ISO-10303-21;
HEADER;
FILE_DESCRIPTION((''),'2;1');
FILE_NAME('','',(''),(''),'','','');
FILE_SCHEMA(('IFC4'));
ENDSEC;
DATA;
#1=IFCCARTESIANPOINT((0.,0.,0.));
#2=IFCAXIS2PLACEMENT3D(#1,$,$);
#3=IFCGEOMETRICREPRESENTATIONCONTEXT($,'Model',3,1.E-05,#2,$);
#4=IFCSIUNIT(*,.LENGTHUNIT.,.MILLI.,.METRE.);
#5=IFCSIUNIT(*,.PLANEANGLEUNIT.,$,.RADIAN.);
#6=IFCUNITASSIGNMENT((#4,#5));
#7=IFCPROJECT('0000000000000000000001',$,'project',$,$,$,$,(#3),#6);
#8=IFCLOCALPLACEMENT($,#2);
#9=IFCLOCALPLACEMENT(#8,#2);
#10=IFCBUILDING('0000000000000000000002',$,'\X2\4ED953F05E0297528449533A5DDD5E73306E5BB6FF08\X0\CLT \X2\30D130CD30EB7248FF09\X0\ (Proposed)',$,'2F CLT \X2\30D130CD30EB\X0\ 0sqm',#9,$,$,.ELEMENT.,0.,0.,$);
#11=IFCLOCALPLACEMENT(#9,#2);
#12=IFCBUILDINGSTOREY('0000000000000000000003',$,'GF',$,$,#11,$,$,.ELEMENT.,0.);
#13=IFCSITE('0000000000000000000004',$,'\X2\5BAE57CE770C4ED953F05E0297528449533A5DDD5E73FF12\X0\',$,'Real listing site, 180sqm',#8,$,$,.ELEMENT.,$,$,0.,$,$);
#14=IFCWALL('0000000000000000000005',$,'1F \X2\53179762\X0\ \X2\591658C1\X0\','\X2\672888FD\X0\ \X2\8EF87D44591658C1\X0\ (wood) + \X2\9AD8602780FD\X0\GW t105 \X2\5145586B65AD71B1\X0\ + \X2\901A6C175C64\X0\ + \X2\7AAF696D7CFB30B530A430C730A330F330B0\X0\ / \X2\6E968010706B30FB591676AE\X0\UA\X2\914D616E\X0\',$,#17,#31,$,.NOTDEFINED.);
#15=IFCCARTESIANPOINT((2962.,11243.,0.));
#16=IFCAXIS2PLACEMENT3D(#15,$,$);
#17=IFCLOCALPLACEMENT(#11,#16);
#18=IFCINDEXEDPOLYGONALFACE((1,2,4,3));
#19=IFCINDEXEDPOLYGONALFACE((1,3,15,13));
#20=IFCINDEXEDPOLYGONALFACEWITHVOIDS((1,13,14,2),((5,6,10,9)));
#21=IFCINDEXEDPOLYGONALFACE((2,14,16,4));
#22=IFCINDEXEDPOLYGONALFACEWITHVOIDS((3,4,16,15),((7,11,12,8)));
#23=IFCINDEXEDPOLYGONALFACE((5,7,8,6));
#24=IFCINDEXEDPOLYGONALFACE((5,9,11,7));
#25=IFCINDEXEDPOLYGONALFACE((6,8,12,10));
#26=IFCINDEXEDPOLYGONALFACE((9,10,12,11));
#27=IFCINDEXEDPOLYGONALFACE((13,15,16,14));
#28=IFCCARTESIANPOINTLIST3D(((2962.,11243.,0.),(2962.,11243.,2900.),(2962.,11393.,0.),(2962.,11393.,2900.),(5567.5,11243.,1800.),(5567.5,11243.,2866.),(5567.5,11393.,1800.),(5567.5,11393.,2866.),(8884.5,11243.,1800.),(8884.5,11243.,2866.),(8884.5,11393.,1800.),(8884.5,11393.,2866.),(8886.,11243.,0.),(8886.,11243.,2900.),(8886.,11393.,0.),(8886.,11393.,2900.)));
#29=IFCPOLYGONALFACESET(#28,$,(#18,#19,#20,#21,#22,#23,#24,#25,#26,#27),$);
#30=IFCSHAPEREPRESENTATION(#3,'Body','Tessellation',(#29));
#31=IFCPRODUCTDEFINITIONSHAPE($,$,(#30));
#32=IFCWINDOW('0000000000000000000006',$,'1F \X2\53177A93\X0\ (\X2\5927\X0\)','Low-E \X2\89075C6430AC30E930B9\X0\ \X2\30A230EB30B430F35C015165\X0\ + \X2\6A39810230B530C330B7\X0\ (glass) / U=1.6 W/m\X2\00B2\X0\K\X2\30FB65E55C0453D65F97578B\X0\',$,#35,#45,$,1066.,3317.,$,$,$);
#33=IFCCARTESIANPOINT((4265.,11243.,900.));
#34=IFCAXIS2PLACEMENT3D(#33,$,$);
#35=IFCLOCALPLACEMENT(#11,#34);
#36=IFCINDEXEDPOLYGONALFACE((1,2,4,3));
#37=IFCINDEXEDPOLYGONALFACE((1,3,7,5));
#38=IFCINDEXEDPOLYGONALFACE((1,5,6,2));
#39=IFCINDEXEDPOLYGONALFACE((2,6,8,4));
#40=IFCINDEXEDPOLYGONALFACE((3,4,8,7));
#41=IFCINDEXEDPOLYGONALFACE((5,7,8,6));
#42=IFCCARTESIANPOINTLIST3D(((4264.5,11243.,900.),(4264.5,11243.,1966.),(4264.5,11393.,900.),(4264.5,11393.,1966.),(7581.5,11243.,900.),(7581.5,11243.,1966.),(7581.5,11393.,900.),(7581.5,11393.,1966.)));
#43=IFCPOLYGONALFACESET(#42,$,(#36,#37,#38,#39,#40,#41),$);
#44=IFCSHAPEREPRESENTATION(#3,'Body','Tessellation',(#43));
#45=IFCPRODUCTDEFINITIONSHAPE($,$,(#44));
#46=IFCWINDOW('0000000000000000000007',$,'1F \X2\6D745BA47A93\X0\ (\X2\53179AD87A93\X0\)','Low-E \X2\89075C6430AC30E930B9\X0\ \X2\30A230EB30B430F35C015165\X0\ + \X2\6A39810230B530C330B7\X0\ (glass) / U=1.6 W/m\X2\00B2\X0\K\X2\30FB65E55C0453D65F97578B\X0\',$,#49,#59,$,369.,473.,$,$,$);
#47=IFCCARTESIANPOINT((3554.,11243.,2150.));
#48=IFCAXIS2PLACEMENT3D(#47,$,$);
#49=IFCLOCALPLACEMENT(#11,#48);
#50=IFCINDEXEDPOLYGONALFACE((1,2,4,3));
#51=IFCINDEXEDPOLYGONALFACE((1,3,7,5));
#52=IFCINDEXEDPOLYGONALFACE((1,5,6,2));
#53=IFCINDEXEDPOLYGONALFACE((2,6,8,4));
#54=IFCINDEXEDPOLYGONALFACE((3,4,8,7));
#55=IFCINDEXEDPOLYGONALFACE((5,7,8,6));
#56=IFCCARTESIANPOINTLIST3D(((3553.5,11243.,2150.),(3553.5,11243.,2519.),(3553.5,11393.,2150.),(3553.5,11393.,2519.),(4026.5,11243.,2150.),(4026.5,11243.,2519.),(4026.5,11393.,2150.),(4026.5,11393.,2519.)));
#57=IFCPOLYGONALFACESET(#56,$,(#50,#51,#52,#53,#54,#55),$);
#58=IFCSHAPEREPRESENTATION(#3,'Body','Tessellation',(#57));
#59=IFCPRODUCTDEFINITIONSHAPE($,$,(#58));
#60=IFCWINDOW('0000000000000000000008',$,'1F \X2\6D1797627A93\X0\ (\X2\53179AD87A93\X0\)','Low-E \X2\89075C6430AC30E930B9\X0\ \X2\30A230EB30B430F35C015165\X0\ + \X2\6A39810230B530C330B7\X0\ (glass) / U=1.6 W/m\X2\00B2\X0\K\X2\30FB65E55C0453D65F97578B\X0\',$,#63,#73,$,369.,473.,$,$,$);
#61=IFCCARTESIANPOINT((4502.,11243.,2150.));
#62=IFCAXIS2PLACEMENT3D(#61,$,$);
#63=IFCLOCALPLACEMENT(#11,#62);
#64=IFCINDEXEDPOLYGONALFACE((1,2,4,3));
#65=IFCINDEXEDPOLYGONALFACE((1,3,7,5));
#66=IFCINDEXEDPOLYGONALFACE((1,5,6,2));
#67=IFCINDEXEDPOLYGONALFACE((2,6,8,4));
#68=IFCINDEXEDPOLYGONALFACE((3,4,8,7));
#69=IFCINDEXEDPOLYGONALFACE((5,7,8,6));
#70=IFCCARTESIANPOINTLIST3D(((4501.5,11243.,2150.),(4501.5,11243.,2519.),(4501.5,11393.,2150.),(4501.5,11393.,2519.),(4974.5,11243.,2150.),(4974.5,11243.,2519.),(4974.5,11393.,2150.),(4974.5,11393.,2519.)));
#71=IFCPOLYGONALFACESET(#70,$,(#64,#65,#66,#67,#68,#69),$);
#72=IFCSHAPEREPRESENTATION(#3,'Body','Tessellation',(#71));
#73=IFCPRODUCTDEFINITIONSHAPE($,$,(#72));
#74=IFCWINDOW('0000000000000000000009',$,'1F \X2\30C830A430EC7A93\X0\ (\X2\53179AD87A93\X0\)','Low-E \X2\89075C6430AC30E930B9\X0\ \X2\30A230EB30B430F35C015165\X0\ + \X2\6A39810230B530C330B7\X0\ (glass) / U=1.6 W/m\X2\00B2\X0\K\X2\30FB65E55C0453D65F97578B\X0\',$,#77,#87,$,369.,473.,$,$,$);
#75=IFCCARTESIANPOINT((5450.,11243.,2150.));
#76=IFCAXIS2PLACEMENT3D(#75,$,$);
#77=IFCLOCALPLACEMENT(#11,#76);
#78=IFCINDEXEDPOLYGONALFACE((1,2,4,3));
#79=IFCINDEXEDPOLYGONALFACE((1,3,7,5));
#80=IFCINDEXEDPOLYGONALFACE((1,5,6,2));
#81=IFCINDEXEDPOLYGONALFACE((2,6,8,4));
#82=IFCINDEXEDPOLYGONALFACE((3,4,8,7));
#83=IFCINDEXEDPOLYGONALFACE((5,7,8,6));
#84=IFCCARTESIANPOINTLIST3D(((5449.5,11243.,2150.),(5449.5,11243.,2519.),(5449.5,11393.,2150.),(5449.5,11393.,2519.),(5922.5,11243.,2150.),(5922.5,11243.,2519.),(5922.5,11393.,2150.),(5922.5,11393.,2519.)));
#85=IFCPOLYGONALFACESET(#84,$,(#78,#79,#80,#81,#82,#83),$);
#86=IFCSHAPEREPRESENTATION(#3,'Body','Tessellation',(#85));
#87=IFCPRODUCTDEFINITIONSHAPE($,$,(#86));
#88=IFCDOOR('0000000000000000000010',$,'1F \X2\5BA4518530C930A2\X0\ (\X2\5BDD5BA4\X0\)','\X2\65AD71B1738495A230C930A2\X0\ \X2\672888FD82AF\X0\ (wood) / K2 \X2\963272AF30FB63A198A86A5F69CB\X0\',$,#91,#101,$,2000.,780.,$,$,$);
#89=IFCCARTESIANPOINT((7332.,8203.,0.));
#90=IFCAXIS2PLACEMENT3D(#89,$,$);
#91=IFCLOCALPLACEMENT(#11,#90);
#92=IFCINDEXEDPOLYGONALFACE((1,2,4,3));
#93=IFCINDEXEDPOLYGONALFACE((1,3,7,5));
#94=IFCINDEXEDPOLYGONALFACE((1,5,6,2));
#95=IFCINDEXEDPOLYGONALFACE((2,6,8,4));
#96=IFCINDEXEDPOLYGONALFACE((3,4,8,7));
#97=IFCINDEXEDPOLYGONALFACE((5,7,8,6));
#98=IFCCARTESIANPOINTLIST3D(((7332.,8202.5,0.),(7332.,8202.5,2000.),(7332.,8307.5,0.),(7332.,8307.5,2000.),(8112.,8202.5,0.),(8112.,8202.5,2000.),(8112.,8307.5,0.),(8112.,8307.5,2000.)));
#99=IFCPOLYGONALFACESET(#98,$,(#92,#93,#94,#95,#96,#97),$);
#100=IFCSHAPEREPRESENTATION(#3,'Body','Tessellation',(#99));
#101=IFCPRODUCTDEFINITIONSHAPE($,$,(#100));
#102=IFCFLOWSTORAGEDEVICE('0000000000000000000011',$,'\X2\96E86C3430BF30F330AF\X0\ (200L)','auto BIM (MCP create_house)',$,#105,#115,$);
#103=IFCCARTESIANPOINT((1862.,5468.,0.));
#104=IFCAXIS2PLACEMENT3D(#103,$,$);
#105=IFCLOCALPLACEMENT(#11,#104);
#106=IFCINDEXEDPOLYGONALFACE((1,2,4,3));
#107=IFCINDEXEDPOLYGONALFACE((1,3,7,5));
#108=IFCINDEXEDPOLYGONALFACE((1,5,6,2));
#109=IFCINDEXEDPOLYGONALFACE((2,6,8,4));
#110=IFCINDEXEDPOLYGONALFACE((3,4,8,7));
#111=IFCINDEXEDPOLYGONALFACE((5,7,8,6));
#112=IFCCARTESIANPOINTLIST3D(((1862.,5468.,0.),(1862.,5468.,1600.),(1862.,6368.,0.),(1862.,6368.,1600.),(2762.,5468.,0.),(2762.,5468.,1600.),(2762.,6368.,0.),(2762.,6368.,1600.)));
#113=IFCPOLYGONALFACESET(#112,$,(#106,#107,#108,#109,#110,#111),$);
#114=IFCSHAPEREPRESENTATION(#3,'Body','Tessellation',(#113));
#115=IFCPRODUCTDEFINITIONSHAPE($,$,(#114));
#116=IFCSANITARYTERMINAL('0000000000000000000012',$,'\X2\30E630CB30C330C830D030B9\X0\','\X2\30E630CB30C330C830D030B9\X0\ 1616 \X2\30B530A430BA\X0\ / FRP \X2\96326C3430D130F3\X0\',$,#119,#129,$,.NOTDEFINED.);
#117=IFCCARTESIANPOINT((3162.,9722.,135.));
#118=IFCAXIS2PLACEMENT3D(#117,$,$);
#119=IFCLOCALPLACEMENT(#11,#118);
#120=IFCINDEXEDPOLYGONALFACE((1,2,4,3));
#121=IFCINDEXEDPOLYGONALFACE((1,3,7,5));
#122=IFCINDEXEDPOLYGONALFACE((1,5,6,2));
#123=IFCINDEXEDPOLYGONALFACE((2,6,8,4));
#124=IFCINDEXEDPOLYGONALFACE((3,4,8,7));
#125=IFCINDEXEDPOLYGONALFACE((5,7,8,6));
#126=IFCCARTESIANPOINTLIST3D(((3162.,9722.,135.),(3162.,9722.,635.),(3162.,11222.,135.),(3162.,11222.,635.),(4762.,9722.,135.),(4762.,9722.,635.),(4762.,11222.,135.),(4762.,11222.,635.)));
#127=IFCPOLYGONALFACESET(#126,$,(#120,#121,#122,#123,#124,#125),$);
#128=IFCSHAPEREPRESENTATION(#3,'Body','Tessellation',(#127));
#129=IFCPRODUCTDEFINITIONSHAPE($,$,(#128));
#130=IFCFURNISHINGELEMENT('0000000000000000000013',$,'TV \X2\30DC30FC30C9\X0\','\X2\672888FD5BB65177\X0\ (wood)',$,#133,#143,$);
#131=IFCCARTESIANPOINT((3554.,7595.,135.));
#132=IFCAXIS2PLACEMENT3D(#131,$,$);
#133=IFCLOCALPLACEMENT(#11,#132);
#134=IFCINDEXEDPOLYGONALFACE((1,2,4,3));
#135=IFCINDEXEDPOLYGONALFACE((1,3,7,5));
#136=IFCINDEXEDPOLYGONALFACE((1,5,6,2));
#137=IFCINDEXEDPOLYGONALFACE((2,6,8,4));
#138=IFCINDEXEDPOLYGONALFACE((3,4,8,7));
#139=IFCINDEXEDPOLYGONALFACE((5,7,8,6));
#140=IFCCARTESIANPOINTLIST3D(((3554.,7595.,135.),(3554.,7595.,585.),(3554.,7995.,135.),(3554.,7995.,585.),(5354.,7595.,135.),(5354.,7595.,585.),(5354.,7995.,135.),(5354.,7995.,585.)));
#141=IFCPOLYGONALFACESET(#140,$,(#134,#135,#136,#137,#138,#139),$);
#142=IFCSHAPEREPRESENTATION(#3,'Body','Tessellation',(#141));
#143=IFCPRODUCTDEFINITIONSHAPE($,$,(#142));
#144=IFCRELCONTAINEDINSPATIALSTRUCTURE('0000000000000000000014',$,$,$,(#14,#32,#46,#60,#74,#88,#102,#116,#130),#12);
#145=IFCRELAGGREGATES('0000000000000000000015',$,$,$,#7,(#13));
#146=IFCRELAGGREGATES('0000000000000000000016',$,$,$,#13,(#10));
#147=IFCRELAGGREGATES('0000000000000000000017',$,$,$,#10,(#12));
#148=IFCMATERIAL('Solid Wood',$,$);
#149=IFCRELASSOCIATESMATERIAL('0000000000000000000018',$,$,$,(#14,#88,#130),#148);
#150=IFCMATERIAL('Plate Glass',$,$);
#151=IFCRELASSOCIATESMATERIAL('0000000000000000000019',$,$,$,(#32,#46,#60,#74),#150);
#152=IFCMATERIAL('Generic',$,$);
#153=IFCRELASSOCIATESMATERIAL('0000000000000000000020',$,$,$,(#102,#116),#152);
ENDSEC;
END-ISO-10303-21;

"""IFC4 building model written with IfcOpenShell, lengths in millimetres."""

from ifc_helpers import new_model, si_unit, frame, frame_2d, origin, place, context, project, spatial, rectangle, extrude, material, element, fill, save


model = new_model("IFC4")

# Units and contexts
model_context = context("Model", 3, precision=1e-05, world=origin())
ifc_project = project(units=[si_unit("LENGTHUNIT", "METRE", prefix="MILLI"), si_unit("PLANEANGLEUNIT", "RADIAN")], contexts=[model_context])

# Site, building, storey
site_placement = place(None, origin())
site = spatial("IfcSite", under=ifc_project, at=site_placement, Name="宮城県仙台市青葉区川平２", ObjectType="Real listing site, 180sqm", CompositionType="ELEMENT", RefElevation=0.0)
building_placement = place(site_placement, origin())
building = spatial("IfcBuilding", under=site, at=building_placement, Name="仙台市青葉区川平の家（CLT パネル版） (Proposed)", ObjectType="2F CLT パネル 0sqm", CompositionType="ELEMENT", ElevationOfRefHeight=0.0, ElevationOfTerrain=0.0)
storey_placement = place(building_placement, origin())
storey = spatial("IfcBuildingStorey", under=building, at=storey_placement, Name="GF", CompositionType="ELEMENT", Elevation=0.0)

# Wall, openings, windows
ifc_material_1 = material(Name="Solid Wood")
wall_1_placement = place(storey_placement, frame((2962.0, 11243.0, 0.0)))
wall_1 = element("IfcWall", 1, at=wall_1_placement, inside=storey, material=ifc_material_1, Name="1F 北面 外壁", Description="木製 軸組外壁 (wood) + 高性能GW t105 充填断熱 + 通気層 + 窯業系サイディング / 準耐火・外皮UA配慮", PredefinedType="NOTDEFINED", context=model_context, shape_type="SweptSolid", body=[
    extrude(rectangle(XDim=5924.0, YDim=150.0, at=frame_2d((2962.0, 75.0))), frame((2962.0, 11243.0, 0.0)), (0.0, 0.0, 1.0), 2900.0),
])
opening_1_placement = place(storey_placement, frame((4265.0, 11243.0, 900.0)))
opening_1 = element("IfcOpeningElement", 2, at=opening_1_placement, cuts=wall_1, PredefinedType="NOTDEFINED", context=model_context, shape_type="SweptSolid", body=[
    extrude(rectangle(XDim=3317.0, YDim=150.0, at=frame_2d((1658.0, 75.0))), frame((4265.0, 11243.0, 900.0)), (0.0, 0.0, 1.0), 1066.0),
])
opening_2_placement = place(storey_placement, frame((3554.0, 11243.0, 2150.0)))
opening_2 = element("IfcOpeningElement", 3, at=opening_2_placement, cuts=wall_1, PredefinedType="NOTDEFINED", context=model_context, shape_type="SweptSolid", body=[
    extrude(rectangle(XDim=473.0, YDim=150.0, at=frame_2d((236.0, 75.0))), frame((3554.0, 11243.0, 2150.0)), (0.0, 0.0, 1.0), 369.0),
])
opening_3_placement = place(storey_placement, frame((4502.0, 11243.0, 2150.0)))
opening_3 = element("IfcOpeningElement", 4, at=opening_3_placement, cuts=wall_1, PredefinedType="NOTDEFINED", context=model_context, shape_type="SweptSolid", body=[
    extrude(rectangle(XDim=473.0, YDim=150.0, at=frame_2d((236.0, 75.0))), frame((4502.0, 11243.0, 2150.0)), (0.0, 0.0, 1.0), 369.0),
])
opening_4_placement = place(storey_placement, frame((5450.0, 11243.0, 2150.0)))
opening_4 = element("IfcOpeningElement", 5, at=opening_4_placement, cuts=wall_1, PredefinedType="NOTDEFINED", context=model_context, shape_type="SweptSolid", body=[
    extrude(rectangle(XDim=473.0, YDim=150.0, at=frame_2d((236.0, 75.0))), frame((5450.0, 11243.0, 2150.0)), (0.0, 0.0, 1.0), 369.0),
])
ifc_material_2 = material(Name="Plate Glass")
window_1_placement = place(storey_placement, frame((4265.0, 11243.0, 900.0)))
window_1 = element("IfcWindow", 6, at=window_1_placement, inside=storey, material=ifc_material_2, Name="1F 北窓 (大)", Description="Low-E 複層ガラス アルゴン封入 + 樹脂サッシ (glass) / U=1.6 W/m²K・日射取得型", OverallHeight=1066.0, OverallWidth=3317.0, context=model_context, shape_type="SweptSolid", body=[
    extrude(rectangle(XDim=3317.0, YDim=150.0, at=frame_2d((1658.0, 75.0))), frame((4265.0, 11243.0, 900.0)), (0.0, 0.0, 1.0), 1066.0),
])
fill(opening_1, window_1)
window_2_placement = place(storey_placement, frame((3554.0, 11243.0, 2150.0)))
window_2 = element("IfcWindow", 7, at=window_2_placement, inside=storey, material=ifc_material_2, Name="1F 浴室窓 (北高窓)", Description="Low-E 複層ガラス アルゴン封入 + 樹脂サッシ (glass) / U=1.6 W/m²K・日射取得型", OverallHeight=369.0, OverallWidth=473.0, context=model_context, shape_type="SweptSolid", body=[
    extrude(rectangle(XDim=473.0, YDim=150.0, at=frame_2d((236.0, 75.0))), frame((3554.0, 11243.0, 2150.0)), (0.0, 0.0, 1.0), 369.0),
])
fill(opening_2, window_2)
window_3_placement = place(storey_placement, frame((4502.0, 11243.0, 2150.0)))
window_3 = element("IfcWindow", 8, at=window_3_placement, inside=storey, material=ifc_material_2, Name="1F 洗面窓 (北高窓)", Description="Low-E 複層ガラス アルゴン封入 + 樹脂サッシ (glass) / U=1.6 W/m²K・日射取得型", OverallHeight=369.0, OverallWidth=473.0, context=model_context, shape_type="SweptSolid", body=[
    extrude(rectangle(XDim=473.0, YDim=150.0, at=frame_2d((236.0, 75.0))), frame((4502.0, 11243.0, 2150.0)), (0.0, 0.0, 1.0), 369.0),
])
fill(opening_3, window_3)
window_4_placement = place(storey_placement, frame((5450.0, 11243.0, 2150.0)))
window_4 = element("IfcWindow", 9, at=window_4_placement, inside=storey, material=ifc_material_2, Name="1F トイレ窓 (北高窓)", Description="Low-E 複層ガラス アルゴン封入 + 樹脂サッシ (glass) / U=1.6 W/m²K・日射取得型", OverallHeight=369.0, OverallWidth=473.0, context=model_context, shape_type="SweptSolid", body=[
    extrude(rectangle(XDim=473.0, YDim=150.0, at=frame_2d((236.0, 75.0))), frame((5450.0, 11243.0, 2150.0)), (0.0, 0.0, 1.0), 369.0),
])
fill(opening_4, window_4)

# Door
door_1_placement = place(storey_placement, frame((7332.0, 8203.0, 0.0)))
element("IfcDoor", 10, at=door_1_placement, inside=storey, material=ifc_material_1, Name="1F 室内ドア (寝室)", Description="断熱玄関ドア 木製芯 (wood) / K2 防犯・採風機構", OverallHeight=2000.0, OverallWidth=780.0, context=model_context, shape_type="SweptSolid", body=[
    extrude(rectangle(XDim=780.0, YDim=105.0, at=frame_2d((390.0, 52.0))), frame((7332.0, 8203.0, 0.0)), (0.0, 0.0, 1.0), 2000.0),
])

# Flow storage device
ifc_material_3 = material(Name="Generic")
flow_storage_device_placement = place(storey_placement, frame((1862.0, 5468.0, 0.0)))
element("IfcFlowStorageDevice", 11, at=flow_storage_device_placement, inside=storey, material=ifc_material_3, Name="雨水タンク (200L)", Description="auto BIM (MCP create_house)", context=model_context, shape_type="SweptSolid", body=[
    extrude(rectangle(XDim=900.0, YDim=900.0, at=frame_2d((450.0, 450.0))), frame((1862.0, 5468.0, 0.0)), (0.0, 0.0, 1.0), 1600.0),
])

# Sanitary terminal
sanitary_terminal_placement = place(storey_placement, frame((3162.0, 9722.0, 135.0)))
element("IfcSanitaryTerminal", 12, at=sanitary_terminal_placement, inside=storey, material=ifc_material_3, Name="ユニットバス", Description="ユニットバス 1616 サイズ / FRP 防水パン", PredefinedType="NOTDEFINED", context=model_context, shape_type="SweptSolid", body=[
    extrude(rectangle(XDim=1600.0, YDim=1500.0, at=frame_2d((800.0, 750.0))), frame((3162.0, 9722.0, 135.0)), (0.0, 0.0, 1.0), 500.0),
])

# Furnishing element
furnishing_placement = place(storey_placement, frame((3554.0, 7595.0, 135.0)))
element("IfcFurnishingElement", 13, at=furnishing_placement, inside=storey, material=ifc_material_1, Name="TV ボード", Description="木製家具 (wood)", context=model_context, shape_type="SweptSolid", body=[
    extrude(rectangle(XDim=1800.0, YDim=400.0, at=frame_2d((900.0, 200.0))), frame((3554.0, 7595.0, 135.0)), (0.0, 0.0, 1.0), 450.0),
])

save(model, "model.ifc")
